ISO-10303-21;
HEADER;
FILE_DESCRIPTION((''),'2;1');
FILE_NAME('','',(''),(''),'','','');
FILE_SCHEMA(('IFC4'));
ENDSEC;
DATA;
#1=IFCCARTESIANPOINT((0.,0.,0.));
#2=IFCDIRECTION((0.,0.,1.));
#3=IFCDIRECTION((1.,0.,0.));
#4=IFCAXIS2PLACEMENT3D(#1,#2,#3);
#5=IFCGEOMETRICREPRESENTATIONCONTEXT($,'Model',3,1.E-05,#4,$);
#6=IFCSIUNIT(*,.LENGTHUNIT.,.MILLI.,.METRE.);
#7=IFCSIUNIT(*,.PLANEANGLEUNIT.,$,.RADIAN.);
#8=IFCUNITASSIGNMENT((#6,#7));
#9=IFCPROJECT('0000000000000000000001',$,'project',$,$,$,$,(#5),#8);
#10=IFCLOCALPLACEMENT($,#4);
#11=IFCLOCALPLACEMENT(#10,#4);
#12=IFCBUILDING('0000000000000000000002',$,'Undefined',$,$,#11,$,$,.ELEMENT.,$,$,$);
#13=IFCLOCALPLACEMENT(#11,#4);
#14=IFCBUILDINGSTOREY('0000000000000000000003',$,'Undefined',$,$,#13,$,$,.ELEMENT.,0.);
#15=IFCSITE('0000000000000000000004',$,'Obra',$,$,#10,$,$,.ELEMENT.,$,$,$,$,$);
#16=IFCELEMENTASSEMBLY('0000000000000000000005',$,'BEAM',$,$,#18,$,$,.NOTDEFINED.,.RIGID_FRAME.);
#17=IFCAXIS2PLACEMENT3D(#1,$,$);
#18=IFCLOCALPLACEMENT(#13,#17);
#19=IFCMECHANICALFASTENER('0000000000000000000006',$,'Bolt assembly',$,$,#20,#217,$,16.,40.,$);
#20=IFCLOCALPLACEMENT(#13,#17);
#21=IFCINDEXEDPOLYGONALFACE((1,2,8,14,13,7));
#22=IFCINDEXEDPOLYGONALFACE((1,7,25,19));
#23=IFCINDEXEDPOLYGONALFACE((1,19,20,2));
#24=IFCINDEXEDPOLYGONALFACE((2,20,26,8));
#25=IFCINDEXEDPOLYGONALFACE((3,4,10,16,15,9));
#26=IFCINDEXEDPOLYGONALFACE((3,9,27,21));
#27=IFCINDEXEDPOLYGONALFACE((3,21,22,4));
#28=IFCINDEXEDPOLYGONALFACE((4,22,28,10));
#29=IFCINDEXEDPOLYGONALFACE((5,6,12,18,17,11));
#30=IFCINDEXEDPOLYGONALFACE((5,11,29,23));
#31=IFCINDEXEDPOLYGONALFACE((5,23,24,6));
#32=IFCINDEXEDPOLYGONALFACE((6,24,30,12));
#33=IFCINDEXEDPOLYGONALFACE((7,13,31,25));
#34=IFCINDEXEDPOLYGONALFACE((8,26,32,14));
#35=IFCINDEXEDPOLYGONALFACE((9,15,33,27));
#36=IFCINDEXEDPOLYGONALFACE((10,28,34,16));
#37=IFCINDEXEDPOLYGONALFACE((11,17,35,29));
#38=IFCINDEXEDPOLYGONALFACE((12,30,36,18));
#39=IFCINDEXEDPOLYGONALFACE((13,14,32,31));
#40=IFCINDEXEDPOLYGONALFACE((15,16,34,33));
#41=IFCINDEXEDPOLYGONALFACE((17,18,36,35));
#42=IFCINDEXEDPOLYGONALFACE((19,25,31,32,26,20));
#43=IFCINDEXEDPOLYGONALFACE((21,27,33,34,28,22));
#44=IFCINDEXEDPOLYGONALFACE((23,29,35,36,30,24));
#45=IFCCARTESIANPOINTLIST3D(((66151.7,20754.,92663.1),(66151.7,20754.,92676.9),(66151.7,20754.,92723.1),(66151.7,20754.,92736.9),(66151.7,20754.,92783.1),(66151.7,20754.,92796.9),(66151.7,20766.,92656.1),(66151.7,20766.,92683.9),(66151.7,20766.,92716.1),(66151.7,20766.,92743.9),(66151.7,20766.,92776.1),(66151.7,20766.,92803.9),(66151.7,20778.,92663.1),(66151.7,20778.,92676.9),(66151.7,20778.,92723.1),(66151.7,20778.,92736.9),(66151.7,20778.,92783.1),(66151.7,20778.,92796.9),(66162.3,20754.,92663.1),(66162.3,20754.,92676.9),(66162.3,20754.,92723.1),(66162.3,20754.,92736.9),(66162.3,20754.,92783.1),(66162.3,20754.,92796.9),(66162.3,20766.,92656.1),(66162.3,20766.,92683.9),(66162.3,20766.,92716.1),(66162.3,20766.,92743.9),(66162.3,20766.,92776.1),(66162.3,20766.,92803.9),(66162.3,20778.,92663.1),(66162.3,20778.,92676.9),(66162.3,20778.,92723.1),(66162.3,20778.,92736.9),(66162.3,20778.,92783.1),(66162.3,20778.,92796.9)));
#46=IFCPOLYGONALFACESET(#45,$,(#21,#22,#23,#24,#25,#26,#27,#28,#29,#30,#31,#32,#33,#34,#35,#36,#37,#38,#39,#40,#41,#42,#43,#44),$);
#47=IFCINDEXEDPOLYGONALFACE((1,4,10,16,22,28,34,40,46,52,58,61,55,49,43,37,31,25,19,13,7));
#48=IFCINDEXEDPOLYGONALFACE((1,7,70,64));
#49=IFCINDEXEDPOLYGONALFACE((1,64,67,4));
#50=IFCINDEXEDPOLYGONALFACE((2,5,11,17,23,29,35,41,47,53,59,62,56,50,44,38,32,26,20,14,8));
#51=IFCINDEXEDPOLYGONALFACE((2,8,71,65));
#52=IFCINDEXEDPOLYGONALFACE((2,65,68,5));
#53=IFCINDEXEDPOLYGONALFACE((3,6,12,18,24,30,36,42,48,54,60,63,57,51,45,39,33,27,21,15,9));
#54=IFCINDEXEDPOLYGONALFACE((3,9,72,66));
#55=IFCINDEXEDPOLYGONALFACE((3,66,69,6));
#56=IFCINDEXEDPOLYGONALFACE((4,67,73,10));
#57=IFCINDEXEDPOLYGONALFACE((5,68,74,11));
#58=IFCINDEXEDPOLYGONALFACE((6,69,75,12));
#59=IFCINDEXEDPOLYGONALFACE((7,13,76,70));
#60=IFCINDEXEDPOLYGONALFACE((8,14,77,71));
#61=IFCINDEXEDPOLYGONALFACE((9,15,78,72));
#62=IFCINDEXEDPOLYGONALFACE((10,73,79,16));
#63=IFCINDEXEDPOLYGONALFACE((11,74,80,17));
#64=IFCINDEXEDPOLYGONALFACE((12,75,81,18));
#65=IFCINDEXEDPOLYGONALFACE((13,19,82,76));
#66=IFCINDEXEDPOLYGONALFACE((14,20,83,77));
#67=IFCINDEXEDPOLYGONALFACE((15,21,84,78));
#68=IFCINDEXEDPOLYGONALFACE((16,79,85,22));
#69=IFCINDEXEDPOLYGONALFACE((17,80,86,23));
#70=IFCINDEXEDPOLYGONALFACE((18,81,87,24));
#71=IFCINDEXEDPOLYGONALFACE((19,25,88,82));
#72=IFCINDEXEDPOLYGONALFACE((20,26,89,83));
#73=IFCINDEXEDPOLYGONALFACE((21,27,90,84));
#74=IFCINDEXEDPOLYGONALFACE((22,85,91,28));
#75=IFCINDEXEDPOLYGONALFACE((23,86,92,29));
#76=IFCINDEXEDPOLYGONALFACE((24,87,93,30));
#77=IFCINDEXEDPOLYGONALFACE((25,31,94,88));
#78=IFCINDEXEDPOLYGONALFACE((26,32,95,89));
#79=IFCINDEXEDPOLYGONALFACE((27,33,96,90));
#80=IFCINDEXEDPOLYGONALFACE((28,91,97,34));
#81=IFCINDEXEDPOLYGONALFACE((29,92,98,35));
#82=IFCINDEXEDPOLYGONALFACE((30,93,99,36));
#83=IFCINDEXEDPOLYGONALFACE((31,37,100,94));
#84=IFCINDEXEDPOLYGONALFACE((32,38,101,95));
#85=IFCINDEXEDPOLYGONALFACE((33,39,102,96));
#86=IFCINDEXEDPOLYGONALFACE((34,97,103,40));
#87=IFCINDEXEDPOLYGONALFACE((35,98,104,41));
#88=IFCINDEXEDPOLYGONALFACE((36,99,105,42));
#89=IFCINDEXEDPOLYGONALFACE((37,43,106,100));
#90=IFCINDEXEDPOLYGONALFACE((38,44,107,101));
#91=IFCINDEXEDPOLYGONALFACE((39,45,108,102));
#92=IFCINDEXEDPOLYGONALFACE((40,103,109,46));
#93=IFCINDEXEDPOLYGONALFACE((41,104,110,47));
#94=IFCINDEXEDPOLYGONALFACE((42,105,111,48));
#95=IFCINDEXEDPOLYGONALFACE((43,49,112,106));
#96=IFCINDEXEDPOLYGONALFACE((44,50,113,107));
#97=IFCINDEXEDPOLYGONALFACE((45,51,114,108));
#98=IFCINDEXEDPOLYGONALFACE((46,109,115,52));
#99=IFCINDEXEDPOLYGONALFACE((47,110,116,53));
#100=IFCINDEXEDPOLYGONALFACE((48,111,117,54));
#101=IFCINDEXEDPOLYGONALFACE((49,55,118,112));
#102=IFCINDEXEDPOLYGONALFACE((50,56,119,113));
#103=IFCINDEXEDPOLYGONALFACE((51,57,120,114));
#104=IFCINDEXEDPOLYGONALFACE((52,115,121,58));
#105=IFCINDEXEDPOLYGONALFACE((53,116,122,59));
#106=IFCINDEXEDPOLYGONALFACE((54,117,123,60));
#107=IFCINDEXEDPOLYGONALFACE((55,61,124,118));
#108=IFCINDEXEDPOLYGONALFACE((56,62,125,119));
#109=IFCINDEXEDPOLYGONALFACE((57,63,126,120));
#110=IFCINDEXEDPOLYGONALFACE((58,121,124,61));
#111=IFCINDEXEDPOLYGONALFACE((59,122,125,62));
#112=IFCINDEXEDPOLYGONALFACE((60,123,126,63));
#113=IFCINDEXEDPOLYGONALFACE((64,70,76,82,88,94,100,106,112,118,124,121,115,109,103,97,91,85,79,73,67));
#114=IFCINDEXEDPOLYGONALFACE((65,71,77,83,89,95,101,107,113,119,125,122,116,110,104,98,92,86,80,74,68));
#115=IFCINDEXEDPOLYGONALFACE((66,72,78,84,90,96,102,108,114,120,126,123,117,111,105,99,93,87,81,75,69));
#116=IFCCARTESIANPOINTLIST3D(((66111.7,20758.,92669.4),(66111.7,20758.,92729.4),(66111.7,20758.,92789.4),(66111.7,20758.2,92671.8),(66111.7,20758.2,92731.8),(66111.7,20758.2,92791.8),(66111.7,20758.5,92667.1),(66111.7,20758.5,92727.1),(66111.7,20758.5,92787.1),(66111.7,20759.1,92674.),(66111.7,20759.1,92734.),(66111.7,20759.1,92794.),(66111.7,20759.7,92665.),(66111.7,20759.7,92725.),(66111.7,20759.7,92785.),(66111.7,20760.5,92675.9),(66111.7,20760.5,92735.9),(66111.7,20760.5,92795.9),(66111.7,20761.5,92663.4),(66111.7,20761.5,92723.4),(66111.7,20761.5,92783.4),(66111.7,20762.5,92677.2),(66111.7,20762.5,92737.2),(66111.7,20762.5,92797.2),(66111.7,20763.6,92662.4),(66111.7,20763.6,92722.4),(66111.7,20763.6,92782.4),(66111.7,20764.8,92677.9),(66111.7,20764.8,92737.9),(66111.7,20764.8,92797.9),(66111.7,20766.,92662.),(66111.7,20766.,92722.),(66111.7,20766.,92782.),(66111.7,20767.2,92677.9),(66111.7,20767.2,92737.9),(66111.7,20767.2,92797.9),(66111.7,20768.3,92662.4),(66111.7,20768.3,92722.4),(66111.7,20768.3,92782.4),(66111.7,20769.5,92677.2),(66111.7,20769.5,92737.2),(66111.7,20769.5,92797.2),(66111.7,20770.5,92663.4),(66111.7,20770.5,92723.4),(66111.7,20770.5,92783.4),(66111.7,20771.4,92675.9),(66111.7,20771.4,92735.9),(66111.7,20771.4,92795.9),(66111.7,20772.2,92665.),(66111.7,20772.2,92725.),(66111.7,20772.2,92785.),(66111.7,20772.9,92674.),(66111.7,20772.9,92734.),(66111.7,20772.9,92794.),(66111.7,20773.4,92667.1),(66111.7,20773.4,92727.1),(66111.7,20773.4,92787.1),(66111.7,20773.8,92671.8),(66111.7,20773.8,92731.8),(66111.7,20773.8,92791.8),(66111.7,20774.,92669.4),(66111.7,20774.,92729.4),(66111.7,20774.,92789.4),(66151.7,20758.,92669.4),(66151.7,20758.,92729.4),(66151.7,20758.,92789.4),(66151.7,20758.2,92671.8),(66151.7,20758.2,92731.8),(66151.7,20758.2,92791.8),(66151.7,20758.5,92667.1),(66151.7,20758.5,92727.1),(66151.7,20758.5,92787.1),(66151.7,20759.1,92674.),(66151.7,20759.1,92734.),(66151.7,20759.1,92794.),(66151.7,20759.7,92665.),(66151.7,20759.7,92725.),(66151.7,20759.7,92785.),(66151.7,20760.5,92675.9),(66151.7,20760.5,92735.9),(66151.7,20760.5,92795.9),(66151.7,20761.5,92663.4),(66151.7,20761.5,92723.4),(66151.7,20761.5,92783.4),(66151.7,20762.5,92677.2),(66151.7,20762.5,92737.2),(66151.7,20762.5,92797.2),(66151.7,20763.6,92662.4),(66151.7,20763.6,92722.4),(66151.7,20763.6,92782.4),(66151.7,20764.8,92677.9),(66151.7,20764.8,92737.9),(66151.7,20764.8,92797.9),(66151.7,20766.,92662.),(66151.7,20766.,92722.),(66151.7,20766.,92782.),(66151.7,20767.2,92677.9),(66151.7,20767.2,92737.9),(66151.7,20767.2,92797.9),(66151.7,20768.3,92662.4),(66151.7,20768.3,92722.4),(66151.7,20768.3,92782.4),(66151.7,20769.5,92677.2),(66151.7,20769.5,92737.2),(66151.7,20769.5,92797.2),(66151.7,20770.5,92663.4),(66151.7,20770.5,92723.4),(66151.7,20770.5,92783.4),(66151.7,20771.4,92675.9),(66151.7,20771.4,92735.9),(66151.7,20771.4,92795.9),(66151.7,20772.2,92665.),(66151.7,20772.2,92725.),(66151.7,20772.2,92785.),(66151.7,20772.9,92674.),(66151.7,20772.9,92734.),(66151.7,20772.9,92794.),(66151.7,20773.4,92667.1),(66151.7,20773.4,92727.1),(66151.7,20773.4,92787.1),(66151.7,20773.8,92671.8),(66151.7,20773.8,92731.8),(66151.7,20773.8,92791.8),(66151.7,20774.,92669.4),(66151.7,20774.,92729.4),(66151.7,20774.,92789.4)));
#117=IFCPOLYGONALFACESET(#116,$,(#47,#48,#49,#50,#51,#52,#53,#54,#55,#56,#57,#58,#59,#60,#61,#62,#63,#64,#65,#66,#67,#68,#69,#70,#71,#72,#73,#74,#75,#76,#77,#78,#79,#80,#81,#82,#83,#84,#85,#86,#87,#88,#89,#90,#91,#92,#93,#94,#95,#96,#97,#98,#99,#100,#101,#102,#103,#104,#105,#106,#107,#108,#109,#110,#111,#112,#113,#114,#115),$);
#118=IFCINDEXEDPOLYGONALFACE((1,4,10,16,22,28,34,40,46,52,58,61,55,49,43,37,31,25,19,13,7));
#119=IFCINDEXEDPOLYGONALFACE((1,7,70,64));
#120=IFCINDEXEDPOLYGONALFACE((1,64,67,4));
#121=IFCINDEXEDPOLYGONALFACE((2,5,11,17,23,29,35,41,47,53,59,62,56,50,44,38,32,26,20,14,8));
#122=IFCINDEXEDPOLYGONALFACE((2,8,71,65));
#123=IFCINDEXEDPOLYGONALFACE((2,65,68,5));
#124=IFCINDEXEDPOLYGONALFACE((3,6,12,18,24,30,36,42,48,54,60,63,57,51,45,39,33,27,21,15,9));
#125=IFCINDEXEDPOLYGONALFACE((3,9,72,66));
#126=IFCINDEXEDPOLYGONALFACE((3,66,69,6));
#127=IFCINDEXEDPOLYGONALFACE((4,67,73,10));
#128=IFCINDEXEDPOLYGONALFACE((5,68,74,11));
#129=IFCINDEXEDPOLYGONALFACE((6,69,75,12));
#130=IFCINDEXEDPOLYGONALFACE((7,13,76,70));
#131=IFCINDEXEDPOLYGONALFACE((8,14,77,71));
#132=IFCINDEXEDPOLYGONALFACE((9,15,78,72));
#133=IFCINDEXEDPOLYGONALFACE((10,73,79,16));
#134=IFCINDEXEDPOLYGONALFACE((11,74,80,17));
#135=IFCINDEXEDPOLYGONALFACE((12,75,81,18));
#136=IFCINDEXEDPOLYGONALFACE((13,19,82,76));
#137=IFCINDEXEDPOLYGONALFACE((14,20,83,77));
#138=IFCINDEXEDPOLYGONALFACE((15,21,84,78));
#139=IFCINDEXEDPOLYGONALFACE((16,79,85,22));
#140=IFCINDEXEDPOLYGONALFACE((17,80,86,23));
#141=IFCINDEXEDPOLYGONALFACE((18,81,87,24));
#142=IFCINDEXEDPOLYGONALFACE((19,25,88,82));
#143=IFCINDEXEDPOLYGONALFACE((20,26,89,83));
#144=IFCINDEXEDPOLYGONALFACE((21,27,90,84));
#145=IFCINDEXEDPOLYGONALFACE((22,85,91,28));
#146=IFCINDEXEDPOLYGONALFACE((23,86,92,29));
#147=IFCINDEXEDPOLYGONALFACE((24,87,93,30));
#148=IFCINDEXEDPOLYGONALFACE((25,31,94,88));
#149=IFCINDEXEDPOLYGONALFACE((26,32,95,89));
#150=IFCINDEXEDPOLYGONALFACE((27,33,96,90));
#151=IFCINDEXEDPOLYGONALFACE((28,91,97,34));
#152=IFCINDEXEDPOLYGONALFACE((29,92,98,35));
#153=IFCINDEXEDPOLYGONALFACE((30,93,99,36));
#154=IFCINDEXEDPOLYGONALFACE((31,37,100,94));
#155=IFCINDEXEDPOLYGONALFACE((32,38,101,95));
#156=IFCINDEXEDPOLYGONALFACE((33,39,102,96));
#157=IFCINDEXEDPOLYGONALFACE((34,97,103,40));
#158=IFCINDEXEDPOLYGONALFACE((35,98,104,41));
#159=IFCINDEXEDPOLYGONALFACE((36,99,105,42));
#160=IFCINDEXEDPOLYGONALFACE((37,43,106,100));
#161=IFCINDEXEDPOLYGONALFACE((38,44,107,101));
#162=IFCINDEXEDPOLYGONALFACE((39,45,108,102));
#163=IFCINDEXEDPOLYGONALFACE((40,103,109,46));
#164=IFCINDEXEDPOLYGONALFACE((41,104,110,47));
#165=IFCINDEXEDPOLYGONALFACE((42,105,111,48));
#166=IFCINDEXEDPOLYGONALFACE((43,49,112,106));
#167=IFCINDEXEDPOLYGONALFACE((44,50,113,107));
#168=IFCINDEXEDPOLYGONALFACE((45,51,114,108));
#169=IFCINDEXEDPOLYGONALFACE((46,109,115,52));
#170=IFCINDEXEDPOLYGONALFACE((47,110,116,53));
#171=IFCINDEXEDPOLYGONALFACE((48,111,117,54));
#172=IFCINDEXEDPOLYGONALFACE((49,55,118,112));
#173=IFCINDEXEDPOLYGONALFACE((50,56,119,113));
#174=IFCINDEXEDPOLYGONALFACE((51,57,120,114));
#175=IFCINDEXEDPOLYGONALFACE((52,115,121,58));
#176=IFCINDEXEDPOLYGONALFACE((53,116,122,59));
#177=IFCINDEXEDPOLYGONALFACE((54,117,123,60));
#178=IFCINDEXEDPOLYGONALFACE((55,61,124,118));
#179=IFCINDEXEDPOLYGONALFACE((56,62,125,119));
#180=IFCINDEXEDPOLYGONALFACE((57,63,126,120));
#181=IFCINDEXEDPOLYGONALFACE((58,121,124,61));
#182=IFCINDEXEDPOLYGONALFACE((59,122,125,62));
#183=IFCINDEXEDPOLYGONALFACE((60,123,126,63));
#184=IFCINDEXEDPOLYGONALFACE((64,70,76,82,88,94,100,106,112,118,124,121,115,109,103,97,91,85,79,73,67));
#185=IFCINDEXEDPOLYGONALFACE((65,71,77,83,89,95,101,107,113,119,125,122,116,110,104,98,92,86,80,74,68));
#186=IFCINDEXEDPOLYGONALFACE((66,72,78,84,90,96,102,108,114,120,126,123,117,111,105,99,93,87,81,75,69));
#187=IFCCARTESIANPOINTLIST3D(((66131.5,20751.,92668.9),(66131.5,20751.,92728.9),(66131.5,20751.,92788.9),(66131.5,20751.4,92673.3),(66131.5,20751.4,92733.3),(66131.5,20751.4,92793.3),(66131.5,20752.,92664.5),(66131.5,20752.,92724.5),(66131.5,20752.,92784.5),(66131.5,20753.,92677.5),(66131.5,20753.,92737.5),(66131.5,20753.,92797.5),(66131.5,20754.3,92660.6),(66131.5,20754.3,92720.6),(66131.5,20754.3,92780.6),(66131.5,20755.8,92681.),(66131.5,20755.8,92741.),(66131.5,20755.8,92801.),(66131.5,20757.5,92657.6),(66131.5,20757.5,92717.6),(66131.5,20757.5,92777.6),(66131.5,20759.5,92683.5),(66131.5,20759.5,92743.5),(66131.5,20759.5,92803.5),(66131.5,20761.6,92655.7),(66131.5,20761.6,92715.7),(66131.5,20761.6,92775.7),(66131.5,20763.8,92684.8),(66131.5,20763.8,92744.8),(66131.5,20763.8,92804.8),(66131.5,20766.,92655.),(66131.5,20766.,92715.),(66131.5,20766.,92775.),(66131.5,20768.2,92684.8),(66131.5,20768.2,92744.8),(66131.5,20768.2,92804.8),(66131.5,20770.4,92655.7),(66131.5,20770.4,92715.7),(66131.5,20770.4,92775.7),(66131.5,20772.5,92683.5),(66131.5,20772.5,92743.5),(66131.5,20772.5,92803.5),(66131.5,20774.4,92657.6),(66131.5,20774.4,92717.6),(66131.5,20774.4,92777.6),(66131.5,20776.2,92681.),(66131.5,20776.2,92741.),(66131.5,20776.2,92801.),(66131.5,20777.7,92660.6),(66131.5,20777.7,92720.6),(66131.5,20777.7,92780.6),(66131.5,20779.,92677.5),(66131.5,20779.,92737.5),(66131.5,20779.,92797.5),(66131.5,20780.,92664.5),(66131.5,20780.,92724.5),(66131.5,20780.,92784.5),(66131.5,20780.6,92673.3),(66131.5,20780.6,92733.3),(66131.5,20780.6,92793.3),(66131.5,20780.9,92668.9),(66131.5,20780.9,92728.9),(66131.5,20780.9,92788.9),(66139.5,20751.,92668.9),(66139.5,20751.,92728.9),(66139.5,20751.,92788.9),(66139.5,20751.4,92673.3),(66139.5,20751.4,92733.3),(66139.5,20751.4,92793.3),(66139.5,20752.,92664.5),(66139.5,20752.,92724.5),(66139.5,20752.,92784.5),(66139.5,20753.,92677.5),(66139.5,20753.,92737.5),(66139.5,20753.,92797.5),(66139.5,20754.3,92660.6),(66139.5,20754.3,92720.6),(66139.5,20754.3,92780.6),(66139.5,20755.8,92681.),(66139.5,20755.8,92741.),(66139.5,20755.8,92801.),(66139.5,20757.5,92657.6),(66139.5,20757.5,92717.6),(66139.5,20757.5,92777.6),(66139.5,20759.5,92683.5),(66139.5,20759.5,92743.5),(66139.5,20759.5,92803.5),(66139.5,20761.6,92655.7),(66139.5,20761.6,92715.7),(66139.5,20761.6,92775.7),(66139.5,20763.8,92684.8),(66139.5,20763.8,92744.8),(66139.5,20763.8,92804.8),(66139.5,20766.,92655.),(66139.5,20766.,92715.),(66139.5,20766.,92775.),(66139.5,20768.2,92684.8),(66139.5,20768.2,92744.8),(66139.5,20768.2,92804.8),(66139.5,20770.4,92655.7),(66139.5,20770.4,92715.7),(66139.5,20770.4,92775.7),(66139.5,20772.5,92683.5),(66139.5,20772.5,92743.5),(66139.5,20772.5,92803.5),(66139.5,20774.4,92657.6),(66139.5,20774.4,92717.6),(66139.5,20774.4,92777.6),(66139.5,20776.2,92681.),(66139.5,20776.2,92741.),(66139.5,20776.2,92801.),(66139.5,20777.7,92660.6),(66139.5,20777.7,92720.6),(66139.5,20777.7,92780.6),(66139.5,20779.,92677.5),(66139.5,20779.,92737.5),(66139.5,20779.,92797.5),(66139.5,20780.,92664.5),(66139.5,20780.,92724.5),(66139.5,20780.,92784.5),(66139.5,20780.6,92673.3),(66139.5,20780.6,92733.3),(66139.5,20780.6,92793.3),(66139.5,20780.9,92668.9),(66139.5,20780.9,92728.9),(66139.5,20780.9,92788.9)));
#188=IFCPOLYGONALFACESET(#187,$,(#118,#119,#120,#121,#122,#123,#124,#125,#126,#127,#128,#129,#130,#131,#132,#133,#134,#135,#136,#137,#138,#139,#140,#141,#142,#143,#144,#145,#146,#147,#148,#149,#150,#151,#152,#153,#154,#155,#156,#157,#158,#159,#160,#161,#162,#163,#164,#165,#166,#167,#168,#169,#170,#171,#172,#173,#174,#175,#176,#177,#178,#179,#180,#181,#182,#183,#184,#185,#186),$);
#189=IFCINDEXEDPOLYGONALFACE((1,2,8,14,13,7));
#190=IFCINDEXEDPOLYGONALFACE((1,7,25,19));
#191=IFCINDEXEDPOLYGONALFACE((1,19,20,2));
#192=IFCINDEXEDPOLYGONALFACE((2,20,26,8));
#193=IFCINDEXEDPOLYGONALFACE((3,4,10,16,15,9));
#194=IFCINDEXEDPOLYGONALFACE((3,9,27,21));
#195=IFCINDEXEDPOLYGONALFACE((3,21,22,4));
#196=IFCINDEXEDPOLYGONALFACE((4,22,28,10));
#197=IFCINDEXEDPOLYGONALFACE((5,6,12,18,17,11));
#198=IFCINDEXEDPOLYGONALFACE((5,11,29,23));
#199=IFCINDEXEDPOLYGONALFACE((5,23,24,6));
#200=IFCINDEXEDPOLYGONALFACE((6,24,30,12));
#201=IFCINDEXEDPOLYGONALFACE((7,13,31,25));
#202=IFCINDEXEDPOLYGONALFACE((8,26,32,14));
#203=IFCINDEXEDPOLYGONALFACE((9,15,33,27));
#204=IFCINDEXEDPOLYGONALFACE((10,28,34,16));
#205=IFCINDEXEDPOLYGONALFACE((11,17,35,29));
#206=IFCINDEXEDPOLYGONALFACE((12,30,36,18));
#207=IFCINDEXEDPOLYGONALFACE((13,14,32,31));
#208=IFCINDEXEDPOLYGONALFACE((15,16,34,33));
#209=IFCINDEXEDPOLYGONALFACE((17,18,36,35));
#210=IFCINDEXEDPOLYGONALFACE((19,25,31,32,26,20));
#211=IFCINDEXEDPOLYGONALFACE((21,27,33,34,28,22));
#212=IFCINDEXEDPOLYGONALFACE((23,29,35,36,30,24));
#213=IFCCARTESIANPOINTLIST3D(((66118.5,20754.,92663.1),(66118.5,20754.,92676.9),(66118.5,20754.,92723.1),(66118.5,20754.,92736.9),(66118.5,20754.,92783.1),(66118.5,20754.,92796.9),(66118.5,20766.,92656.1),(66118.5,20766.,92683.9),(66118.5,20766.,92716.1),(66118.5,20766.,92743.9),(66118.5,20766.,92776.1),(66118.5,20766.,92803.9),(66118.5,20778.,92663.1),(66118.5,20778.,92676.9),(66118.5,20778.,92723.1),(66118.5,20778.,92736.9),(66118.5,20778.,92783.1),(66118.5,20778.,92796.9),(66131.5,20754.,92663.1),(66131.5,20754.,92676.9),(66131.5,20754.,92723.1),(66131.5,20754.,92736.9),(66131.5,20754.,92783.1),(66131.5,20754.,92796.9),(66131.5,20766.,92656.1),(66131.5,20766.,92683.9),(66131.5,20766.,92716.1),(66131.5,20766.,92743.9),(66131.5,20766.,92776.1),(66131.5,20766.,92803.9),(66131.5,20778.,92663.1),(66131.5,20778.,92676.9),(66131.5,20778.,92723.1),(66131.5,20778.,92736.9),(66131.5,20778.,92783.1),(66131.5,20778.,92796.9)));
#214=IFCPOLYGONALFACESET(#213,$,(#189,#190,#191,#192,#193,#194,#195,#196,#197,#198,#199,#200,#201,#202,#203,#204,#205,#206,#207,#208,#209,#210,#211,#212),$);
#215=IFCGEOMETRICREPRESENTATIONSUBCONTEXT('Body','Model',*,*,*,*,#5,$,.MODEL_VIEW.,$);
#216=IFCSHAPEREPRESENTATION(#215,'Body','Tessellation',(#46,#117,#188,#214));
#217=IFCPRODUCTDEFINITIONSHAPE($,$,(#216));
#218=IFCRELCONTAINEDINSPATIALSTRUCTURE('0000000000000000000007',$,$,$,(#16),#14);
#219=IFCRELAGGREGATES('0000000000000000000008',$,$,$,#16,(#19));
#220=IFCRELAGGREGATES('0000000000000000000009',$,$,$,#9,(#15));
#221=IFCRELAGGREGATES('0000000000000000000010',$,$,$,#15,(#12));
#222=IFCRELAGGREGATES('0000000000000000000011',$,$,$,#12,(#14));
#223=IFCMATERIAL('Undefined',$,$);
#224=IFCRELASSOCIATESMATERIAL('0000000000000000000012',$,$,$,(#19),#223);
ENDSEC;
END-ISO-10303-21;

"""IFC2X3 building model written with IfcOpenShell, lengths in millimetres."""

from ifc_helpers import new_model, si_unit, frame, origin_with_axes, origin_2d_with_axis, place, context, subcontext, project, spatial, polyline, circle, outline, extrude, source, transform, mapped, material, element, aggregate, save


model = new_model("IFC2X3")

# Units and contexts
model_context = context("Model", 3, precision=1e-05, world=origin_with_axes())
body_context = subcontext(model_context, "Body", "Model", "MODEL_VIEW")
ifc_project = project(units=[si_unit("LENGTHUNIT", "METRE", prefix="MILLI"), si_unit("PLANEANGLEUNIT", "RADIAN")], contexts=[model_context])

# Site, building, storey
site_placement = place(None, origin_with_axes())
site = spatial("IfcSite", under=ifc_project, at=site_placement, Name="Obra", CompositionType="ELEMENT")
building_placement = place(site_placement, origin_with_axes())
building = spatial("IfcBuilding", under=site, at=building_placement, Name="Undefined", CompositionType="ELEMENT")
storey_placement = place(building_placement, origin_with_axes())
storey = spatial("IfcBuildingStorey", under=building, at=storey_placement, Name="Undefined", CompositionType="ELEMENT", Elevation=0.0)

# Shared definitions
ifc_material_1 = material(Name="Undefined")

# Element assembly, mechanical fastener
assembly_1_placement = place(storey_placement, origin_with_axes())
assembly_1 = element("IfcElementAssembly", 1, at=assembly_1_placement, inside=storey, Name="BEAM", AssemblyPlace="NOTDEFINED", PredefinedType="RIGID_FRAME")
shared_shape_1 = source(origin_with_axes(), body_context, "Body", "SweptSolid", [
    extrude(outline(polyline([(13.9, 0.0), (6.9, 12.0), (-6.9, 12.0), (-13.9, 0.0), (-6.9, -12.0), (6.9, -12.0), (13.9, 0.0)])), frame((0.0, -19.7, 0.0), z_axis=(0.0, 1.0, 0.0), x_axis=(1.0, 0.0, 0.0)), (0.0, 0.0, 1.0), 10.6),
    extrude(circle(Radius=8.0, at=origin_2d_with_axis()), frame((0.0, -9.1, 0.0), z_axis=(0.0, 1.0, 0.0), x_axis=(1.0, 0.0, 0.0)), (0.0, 0.0, 1.0), 40.0),
    extrude(circle(Radius=15.0, at=origin_2d_with_axis()), frame((0.0, 3.1, 0.0), z_axis=(0.0, 1.0, 0.0), x_axis=(1.0, 0.0, 0.0)), (0.0, 0.0, 1.0), 8.0),
    extrude(outline(polyline([(13.9, 0.0), (6.9, 12.0), (-6.9, 12.0), (-13.9, 0.0), (-6.9, -12.0), (6.9, -12.0), (13.9, 0.0)])), frame((0.0, 11.1, 0.0), z_axis=(0.0, 1.0, 0.0), x_axis=(1.0, 0.0, 0.0)), (0.0, 0.0, 1.0), 13.0),
])
mechanical_fastener_1_placement = place(assembly_1_placement, frame((66142.6, 20716.0, 92850.0), z_axis=(-0.000002, 1.0, 0.0), x_axis=(0.0, 0.0, -1.0)))
mechanical_fastener_1 = element("IfcMechanicalFastener", 2, at=mechanical_fastener_1_placement, material=ifc_material_1, Name="Bolt assembly", NominalDiameter=16.0, NominalLength=40.0, context=body_context, shape_type="MappedRepresentation", body=[
    mapped(shared_shape_1, transform((60.0, 0.0, 50.0))),
    mapped(shared_shape_1, transform((120.0, 0.0, 50.0))),
    mapped(shared_shape_1, transform((180.0, 0.0, 50.0))),
])

aggregate(assembly_1, [mechanical_fastener_1])

save(model, "model.ifc")
